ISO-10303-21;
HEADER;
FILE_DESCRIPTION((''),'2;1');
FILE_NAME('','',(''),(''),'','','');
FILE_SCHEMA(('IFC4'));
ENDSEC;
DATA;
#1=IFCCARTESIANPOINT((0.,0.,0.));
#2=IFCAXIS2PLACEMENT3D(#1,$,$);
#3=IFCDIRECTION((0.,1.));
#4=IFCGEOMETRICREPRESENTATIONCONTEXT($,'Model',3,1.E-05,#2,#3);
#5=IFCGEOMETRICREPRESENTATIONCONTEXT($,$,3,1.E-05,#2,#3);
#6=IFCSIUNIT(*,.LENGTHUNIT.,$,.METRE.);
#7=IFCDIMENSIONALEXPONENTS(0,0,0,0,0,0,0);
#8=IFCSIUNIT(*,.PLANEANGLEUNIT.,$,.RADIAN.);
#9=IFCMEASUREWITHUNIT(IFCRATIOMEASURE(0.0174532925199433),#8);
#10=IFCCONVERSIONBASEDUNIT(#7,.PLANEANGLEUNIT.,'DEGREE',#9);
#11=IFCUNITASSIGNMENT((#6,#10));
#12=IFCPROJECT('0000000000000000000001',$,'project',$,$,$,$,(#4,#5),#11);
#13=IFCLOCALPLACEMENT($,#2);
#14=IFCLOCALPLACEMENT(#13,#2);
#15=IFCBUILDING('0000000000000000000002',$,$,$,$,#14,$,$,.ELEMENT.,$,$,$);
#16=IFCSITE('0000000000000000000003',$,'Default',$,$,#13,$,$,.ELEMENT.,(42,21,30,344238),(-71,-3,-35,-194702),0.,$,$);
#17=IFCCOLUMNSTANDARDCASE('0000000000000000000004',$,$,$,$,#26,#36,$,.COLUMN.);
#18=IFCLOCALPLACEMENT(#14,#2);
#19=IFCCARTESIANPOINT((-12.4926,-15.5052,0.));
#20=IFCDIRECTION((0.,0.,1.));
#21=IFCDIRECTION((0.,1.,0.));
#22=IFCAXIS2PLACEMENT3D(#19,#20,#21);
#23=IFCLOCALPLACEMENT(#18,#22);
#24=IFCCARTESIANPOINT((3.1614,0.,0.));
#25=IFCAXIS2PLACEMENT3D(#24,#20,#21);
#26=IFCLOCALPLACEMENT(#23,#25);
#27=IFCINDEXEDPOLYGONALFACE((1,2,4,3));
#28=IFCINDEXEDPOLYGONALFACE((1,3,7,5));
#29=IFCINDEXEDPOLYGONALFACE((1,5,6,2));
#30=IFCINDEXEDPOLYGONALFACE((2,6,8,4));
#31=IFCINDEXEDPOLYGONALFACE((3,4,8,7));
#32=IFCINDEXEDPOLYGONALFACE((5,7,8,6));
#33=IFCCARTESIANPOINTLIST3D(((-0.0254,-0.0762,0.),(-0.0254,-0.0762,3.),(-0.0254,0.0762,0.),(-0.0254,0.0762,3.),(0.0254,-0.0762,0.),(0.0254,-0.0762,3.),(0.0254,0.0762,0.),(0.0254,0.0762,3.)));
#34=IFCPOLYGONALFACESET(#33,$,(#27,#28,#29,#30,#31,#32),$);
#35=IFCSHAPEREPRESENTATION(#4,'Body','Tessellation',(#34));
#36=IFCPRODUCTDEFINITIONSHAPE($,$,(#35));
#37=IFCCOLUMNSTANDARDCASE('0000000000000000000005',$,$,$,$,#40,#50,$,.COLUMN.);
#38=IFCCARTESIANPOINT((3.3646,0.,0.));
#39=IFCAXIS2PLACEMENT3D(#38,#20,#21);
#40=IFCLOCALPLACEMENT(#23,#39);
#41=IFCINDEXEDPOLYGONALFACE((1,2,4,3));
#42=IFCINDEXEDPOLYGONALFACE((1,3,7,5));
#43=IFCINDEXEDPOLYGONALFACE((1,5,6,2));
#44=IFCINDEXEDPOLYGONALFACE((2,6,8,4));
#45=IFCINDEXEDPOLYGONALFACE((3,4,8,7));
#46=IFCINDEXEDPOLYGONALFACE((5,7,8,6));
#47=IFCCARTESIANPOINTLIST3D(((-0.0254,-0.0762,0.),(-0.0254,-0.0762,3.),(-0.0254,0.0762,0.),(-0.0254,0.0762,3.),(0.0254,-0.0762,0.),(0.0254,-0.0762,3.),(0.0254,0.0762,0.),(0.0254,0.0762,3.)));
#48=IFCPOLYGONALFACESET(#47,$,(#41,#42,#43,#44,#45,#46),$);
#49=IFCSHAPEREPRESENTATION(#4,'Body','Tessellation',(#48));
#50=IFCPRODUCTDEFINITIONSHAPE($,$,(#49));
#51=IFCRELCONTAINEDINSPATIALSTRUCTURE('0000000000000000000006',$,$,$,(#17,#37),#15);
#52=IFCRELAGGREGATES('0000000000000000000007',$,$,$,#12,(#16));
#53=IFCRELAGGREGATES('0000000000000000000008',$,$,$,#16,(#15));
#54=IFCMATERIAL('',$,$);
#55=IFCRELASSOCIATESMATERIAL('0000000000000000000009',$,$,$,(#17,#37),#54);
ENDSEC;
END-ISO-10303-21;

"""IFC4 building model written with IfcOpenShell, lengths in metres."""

from ifc_helpers import new_model, entity, si_unit, converted_unit, direction, frame, origin, place, context, project, spatial, rectangle, extrude, material, element, save


model = new_model("IFC4")

# Units and contexts
model_context = context("Model", 3, precision=1e-05, world=origin(), true_north=direction((0.0, 1.0)))
context_of_model = context(None, 3, precision=1e-05, world=origin(), true_north=direction((0.0, 1.0)))
ifc_project = project(units=[si_unit("LENGTHUNIT", "METRE"), converted_unit("PLANEANGLEUNIT", "DEGREE", entity("IfcRatioMeasure", 0.0174532925199433), si_unit("PLANEANGLEUNIT", "RADIAN"), dimensions=[0, 0, 0, 0, 0, 0, 0])], contexts=[model_context, context_of_model])

# Site, building
site_placement = place(None, origin())
site = spatial("IfcSite", under=ifc_project, at=site_placement, Name="Default", CompositionType="ELEMENT", RefLatitude=(42, 21, 30, 344238), RefLongitude=(-71, -3, -35, -194702), RefElevation=0.0)
building_placement = place(site_placement, origin())
building = spatial("IfcBuilding", under=site, at=building_placement, CompositionType="ELEMENT")

# Columns
placement_1 = place(building_placement, origin())
ifc_material_1 = material(Name="")
placement_2 = place(placement_1, frame((-12.4926, -15.5052, 0.0), z_axis=(0.0, 0.0, 1.0), x_axis=(0.0, 1.0, 0.0)))
for number, where, z_axis, x_axis in (
    (1, (3.1614, 0.0, 0.0), (0.0, 0.0, 1.0), (0.0, 1.0, 0.0)),
    (2, (3.3646, 0.0, 0.0), (0.0, 0.0, 1.0), (0.0, 1.0, 0.0)),
):
    element("IfcColumnStandardCase", number, at=place(placement_2, frame(where, z_axis=z_axis, x_axis=x_axis)), inside=building, material=ifc_material_1, PredefinedType="COLUMN", context=model_context, shape_type="SweptSolid", body=[
        extrude(rectangle(XDim=0.0508, YDim=0.1524), origin(), (0.0, 0.0, 1.0), 3.0),
    ])

save(model, "model.ifc")
